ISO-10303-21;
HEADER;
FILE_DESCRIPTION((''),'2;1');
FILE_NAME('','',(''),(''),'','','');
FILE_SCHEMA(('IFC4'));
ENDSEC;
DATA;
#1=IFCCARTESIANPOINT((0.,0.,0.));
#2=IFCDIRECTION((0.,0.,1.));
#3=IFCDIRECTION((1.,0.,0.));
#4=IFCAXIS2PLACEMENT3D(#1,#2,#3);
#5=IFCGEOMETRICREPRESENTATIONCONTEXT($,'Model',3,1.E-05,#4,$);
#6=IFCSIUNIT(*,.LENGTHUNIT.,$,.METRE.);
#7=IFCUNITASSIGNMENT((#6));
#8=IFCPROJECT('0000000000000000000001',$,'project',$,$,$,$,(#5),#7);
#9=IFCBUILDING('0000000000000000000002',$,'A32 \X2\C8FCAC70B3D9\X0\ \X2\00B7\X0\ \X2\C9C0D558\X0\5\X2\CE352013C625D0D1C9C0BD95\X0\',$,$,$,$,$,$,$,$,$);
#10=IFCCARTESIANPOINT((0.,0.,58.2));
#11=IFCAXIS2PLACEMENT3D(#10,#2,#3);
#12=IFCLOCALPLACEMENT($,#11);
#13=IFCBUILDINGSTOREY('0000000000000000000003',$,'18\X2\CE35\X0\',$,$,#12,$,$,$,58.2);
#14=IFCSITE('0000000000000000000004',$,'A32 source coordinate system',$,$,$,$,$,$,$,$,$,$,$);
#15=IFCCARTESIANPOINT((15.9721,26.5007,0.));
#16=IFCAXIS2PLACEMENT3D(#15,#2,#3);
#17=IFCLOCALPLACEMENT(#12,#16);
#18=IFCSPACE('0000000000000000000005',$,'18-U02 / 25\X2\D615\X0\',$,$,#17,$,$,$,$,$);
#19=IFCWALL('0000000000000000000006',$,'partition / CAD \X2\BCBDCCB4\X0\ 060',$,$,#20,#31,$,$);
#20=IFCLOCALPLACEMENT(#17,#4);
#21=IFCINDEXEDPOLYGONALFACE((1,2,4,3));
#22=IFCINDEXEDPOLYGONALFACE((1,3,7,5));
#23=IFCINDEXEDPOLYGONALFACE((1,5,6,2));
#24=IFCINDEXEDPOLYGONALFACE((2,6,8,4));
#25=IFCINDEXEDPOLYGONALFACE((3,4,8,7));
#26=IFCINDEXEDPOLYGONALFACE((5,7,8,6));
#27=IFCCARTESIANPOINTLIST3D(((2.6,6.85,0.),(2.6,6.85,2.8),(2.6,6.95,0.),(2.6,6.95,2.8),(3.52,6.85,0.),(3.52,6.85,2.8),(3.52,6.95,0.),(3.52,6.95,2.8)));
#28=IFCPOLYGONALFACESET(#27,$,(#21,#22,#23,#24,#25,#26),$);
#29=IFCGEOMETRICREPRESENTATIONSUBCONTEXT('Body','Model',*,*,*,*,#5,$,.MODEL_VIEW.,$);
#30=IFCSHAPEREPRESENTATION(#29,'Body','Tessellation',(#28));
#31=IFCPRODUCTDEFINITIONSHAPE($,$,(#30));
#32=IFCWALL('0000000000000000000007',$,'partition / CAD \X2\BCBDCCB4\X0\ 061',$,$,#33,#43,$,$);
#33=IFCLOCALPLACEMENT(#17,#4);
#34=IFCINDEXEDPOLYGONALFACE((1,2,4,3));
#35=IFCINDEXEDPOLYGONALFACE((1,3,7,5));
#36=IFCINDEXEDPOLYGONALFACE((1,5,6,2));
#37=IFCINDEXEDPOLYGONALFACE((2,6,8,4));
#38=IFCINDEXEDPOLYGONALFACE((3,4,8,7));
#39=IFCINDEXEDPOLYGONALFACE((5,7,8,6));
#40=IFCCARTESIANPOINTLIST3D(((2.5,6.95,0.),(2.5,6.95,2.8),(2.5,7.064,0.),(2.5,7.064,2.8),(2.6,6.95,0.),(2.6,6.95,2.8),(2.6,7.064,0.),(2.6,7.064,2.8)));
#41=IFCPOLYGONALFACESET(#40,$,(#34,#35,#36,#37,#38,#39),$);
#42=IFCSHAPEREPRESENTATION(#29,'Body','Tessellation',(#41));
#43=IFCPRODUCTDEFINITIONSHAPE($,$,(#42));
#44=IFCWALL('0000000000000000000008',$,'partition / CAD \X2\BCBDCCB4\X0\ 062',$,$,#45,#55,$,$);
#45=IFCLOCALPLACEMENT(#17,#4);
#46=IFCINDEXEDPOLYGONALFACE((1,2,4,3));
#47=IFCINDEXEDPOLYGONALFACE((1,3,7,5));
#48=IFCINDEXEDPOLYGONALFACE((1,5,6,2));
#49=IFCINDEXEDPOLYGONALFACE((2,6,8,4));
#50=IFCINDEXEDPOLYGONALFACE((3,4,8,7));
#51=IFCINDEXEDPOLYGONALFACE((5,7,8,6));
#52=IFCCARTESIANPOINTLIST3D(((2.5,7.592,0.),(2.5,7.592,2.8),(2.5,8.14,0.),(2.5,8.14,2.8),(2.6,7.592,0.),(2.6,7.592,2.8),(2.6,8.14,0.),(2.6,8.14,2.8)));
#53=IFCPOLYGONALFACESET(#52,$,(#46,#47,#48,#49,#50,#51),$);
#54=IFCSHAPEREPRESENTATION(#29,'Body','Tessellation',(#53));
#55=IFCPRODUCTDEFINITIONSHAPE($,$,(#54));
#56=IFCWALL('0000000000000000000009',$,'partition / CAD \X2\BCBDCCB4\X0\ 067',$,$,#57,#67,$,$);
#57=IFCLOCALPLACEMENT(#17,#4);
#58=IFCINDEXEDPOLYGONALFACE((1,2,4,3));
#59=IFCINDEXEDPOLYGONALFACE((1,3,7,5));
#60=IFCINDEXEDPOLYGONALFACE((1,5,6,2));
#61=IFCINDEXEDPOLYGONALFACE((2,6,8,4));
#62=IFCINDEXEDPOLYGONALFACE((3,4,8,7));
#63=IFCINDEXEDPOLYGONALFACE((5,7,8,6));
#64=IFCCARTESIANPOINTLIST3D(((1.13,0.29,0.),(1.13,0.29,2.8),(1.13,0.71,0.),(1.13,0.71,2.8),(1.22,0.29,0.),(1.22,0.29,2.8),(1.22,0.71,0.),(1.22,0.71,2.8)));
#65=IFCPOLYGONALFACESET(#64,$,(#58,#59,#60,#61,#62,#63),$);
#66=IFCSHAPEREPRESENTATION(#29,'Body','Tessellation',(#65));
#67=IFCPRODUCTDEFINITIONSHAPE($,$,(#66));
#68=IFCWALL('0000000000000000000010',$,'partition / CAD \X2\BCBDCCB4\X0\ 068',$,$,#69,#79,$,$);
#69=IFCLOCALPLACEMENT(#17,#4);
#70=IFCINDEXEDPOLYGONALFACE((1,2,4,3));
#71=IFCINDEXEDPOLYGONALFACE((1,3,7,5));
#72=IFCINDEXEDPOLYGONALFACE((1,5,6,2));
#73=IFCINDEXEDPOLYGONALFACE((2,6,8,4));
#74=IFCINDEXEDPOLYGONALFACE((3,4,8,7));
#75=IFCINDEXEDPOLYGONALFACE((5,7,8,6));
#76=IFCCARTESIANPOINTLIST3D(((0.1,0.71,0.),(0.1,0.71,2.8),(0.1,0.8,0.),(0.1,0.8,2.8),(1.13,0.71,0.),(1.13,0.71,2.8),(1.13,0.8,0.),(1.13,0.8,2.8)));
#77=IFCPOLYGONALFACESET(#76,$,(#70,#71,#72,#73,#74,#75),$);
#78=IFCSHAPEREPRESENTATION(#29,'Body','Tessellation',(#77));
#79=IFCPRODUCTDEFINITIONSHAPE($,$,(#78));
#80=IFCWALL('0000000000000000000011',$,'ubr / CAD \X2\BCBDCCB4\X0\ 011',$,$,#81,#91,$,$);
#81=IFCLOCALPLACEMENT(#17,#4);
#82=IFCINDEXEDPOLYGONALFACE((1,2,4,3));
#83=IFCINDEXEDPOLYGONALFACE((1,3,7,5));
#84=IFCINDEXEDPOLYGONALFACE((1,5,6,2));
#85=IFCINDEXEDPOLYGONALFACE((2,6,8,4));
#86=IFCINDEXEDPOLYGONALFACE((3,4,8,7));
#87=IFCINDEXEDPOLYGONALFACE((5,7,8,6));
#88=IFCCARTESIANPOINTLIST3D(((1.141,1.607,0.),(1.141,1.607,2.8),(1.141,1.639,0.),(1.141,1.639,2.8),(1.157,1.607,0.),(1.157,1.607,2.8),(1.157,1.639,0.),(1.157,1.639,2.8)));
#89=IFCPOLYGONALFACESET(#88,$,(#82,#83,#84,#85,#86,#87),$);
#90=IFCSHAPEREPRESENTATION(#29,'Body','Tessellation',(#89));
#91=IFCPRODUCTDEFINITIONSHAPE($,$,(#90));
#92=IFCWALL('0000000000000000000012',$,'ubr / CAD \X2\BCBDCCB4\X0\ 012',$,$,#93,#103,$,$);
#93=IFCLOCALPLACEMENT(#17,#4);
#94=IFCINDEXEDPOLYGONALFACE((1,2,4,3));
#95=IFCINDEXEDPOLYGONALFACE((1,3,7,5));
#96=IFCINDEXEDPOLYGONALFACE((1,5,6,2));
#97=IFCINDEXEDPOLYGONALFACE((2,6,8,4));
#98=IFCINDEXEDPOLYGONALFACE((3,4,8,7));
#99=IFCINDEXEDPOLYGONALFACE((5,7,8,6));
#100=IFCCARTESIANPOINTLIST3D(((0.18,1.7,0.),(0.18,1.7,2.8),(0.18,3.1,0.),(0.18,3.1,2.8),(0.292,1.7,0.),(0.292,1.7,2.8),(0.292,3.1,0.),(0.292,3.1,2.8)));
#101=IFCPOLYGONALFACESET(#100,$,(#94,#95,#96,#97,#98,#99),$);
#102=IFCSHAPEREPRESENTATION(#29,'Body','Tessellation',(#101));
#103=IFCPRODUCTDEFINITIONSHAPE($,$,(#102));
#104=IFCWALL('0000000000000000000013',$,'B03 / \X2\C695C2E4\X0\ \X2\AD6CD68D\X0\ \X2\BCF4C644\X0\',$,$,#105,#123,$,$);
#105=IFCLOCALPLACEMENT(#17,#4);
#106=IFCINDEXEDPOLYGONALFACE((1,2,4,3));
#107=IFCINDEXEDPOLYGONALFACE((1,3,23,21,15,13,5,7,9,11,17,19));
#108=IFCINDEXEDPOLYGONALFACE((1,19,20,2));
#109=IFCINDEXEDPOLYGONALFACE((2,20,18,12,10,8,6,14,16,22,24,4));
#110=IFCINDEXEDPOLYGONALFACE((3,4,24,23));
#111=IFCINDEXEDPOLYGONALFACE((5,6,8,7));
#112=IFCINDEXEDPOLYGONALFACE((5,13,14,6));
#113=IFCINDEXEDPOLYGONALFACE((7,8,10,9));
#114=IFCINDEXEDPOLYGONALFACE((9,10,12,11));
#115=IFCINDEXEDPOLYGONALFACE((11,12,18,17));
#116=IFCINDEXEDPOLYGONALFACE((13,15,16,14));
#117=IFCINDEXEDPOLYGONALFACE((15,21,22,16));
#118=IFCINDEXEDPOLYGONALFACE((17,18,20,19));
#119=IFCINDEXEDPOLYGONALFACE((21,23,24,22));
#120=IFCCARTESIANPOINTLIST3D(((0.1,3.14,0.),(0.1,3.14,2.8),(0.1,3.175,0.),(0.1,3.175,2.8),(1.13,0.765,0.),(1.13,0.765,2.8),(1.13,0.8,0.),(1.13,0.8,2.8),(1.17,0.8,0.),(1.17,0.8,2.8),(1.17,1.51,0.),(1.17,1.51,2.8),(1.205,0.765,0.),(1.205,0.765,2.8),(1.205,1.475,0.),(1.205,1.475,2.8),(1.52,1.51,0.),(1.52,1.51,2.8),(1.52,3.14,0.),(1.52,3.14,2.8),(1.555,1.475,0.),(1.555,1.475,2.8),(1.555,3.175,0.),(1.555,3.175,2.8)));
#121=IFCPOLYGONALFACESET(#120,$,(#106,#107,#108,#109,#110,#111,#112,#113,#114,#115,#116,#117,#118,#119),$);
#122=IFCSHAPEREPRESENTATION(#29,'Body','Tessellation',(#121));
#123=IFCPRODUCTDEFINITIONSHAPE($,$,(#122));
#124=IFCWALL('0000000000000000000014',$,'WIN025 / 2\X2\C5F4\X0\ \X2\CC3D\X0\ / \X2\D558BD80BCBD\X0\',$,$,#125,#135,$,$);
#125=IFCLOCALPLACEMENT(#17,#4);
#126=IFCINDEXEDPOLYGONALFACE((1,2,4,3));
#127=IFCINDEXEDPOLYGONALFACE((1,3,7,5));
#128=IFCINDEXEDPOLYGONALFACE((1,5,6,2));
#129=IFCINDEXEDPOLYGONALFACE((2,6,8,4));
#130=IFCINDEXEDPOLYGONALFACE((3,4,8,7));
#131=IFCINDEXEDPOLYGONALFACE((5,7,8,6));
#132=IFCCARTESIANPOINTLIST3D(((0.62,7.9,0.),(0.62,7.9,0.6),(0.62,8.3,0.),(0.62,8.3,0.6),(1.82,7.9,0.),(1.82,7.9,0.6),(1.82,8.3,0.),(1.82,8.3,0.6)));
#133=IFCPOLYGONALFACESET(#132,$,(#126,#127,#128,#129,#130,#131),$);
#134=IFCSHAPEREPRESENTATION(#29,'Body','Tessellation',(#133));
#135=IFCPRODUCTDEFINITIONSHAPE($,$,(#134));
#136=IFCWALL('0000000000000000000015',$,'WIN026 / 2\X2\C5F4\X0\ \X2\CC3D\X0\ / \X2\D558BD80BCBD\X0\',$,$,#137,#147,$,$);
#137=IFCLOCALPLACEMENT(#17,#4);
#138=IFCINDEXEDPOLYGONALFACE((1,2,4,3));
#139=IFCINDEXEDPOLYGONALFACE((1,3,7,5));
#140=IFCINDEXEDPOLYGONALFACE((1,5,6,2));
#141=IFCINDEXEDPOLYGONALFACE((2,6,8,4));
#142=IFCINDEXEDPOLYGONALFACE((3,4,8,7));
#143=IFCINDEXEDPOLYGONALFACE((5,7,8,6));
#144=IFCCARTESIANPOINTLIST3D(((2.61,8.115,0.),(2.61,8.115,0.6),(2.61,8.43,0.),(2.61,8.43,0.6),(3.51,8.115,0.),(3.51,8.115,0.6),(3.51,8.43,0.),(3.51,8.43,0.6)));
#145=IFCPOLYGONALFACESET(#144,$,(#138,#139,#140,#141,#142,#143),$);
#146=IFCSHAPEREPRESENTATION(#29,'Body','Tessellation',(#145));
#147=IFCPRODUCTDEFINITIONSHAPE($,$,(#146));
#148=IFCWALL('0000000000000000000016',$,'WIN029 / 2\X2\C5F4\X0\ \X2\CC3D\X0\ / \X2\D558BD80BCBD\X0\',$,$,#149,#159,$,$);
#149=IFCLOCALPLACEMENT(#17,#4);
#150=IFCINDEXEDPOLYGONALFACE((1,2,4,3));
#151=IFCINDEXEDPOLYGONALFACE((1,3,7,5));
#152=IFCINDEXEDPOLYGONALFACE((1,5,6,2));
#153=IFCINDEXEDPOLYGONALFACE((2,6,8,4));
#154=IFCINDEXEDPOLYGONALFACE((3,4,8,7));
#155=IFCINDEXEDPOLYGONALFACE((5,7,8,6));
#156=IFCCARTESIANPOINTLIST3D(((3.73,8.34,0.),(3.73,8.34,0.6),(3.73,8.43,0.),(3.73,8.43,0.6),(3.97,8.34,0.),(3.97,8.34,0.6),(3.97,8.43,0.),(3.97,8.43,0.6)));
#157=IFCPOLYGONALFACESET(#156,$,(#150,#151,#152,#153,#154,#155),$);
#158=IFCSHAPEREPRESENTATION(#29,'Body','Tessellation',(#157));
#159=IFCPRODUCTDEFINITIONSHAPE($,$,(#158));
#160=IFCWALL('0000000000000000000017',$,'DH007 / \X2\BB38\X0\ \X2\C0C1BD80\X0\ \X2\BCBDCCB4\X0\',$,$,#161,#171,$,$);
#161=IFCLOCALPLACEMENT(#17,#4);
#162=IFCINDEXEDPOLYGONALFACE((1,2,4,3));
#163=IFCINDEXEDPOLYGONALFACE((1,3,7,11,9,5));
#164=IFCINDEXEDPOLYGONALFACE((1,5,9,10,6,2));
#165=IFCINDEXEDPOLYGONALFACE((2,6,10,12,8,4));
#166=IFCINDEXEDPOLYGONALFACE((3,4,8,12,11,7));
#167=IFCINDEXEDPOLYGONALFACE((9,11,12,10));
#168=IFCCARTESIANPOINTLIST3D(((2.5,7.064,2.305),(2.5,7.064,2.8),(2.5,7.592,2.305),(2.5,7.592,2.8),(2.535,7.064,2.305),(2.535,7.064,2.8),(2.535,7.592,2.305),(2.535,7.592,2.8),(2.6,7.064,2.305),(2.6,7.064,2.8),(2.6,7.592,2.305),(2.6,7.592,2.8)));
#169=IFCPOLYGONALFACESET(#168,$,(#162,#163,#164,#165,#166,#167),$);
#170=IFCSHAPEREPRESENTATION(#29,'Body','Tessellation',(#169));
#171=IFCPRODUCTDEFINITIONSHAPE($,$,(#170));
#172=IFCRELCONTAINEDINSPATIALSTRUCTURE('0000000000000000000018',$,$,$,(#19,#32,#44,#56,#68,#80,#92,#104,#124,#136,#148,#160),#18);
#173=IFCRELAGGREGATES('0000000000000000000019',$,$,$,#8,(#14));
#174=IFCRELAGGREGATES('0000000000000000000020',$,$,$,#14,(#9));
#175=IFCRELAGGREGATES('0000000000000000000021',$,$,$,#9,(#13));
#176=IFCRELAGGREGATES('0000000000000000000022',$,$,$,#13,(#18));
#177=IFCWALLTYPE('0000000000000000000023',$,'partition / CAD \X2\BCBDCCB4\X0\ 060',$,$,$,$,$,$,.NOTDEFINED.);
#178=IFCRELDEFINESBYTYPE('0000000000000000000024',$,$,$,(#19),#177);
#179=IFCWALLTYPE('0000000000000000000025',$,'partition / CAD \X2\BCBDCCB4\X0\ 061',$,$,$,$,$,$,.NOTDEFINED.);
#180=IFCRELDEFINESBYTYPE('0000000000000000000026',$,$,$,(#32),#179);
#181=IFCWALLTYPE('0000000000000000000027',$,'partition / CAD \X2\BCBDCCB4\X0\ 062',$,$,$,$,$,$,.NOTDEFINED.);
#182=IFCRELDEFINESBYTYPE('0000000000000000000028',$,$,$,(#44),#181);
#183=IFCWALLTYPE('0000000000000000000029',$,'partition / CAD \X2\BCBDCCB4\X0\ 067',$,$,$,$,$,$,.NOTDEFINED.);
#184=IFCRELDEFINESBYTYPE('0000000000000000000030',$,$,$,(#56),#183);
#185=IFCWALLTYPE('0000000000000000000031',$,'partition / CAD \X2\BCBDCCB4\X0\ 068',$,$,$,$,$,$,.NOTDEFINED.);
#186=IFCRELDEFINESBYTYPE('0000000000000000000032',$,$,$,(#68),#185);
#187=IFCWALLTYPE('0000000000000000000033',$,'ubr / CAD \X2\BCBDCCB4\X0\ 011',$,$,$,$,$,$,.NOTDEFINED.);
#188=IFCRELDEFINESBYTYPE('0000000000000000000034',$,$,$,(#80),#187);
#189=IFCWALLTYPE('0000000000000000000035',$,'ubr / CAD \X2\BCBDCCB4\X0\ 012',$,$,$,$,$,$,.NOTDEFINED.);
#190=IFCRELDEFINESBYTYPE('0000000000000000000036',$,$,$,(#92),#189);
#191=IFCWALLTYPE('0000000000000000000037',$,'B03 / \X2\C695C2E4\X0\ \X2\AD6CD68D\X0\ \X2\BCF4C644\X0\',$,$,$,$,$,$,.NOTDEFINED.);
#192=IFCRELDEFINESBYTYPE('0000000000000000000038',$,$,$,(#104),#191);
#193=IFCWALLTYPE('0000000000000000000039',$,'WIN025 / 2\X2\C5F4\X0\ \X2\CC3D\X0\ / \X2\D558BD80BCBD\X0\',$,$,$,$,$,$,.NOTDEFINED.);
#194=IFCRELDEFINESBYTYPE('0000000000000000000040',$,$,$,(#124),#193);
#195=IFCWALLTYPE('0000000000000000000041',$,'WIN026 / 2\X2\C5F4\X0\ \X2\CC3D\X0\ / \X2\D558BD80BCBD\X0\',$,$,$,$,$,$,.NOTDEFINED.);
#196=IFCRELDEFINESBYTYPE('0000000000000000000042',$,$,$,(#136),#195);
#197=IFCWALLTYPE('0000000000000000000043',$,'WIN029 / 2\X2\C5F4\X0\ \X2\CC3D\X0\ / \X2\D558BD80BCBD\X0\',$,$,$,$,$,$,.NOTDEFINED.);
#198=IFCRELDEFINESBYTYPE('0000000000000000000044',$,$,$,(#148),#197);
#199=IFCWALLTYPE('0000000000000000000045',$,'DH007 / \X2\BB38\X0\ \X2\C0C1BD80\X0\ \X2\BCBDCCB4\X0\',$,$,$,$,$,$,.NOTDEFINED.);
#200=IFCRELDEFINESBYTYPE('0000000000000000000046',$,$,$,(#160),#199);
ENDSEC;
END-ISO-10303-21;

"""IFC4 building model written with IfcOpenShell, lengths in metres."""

from ifc_helpers import new_model, si_unit, frame, origin, origin_with_axes, place, context, subcontext, project, spatial, polyline, outline, extrude, source, transform, mapped, type_object, type_shapes, element, save


model = new_model("IFC4")

# Units and contexts
model_context = context("Model", 3, precision=1e-05, world=origin_with_axes())
body_context = subcontext(model_context, "Body", "Model", "MODEL_VIEW")
ifc_project = project(units=[si_unit("LENGTHUNIT", "METRE")], contexts=[model_context])

# Site, building, storey, space
site = spatial("IfcSite", under=ifc_project, Name="A32 source coordinate system")
building = spatial("IfcBuilding", under=site, Name="A32 주거동 · 지하5층–옥탑지붕")
storey_placement = place(None, frame((0.0, 0.0, 58.2), z_axis=(0.0, 0.0, 1.0), x_axis=(1.0, 0.0, 0.0)))
storey = spatial("IfcBuildingStorey", under=building, at=storey_placement, Name="18층", Elevation=58.2)
space_1_placement = place(storey_placement, frame((15.9721, 26.5007, 0.0), z_axis=(0.0, 0.0, 1.0), x_axis=(1.0, 0.0, 0.0)))
space_1 = spatial("IfcSpace", under=storey, at=space_1_placement, Name="18-U02 / 25형")

# Walls
wall_type_1 = type_object("IfcWallType", Name="partition / CAD 벽체 060", PredefinedType="NOTDEFINED")
shared_shape_1 = source(origin(), body_context, "Body", "SweptSolid", [
    extrude(outline(polyline([(3.52, 6.85), (2.6, 6.85), (2.6, 6.95), (3.52, 6.95), (3.52, 6.85)])), origin(), (0.0, 0.0, 1.0), 2.8),
])
type_shapes(wall_type_1, [shared_shape_1])
wall_1_placement = place(space_1_placement, origin_with_axes())
element("IfcWall", 1, at=wall_1_placement, inside=space_1, type_object=wall_type_1, Name="partition / CAD 벽체 060", context=body_context, shape_type="MappedRepresentation", body=[
    mapped(shared_shape_1, transform((0.0, 0.0, 0.0), scale=1.0)),
])
wall_type_2 = type_object("IfcWallType", Name="partition / CAD 벽체 061", PredefinedType="NOTDEFINED")
shared_shape_2 = source(origin(), body_context, "Body", "SweptSolid", [
    extrude(outline(polyline([(2.6, 7.064), (2.6, 6.95), (2.5, 6.95), (2.5, 7.064), (2.6, 7.064)])), origin(), (0.0, 0.0, 1.0), 2.8),
])
type_shapes(wall_type_2, [shared_shape_2])
wall_2_placement = place(space_1_placement, origin_with_axes())
element("IfcWall", 2, at=wall_2_placement, inside=space_1, type_object=wall_type_2, Name="partition / CAD 벽체 061", context=body_context, shape_type="MappedRepresentation", body=[
    mapped(shared_shape_2, transform((0.0, 0.0, 0.0), scale=1.0)),
])
wall_type_3 = type_object("IfcWallType", Name="partition / CAD 벽체 062", PredefinedType="NOTDEFINED")
shared_shape_3 = source(origin(), body_context, "Body", "SweptSolid", [
    extrude(outline(polyline([(2.5, 7.592), (2.5, 8.14), (2.6, 8.14), (2.6, 7.592), (2.5, 7.592)])), origin(), (0.0, 0.0, 1.0), 2.8),
])
type_shapes(wall_type_3, [shared_shape_3])
wall_3_placement = place(space_1_placement, origin_with_axes())
element("IfcWall", 3, at=wall_3_placement, inside=space_1, type_object=wall_type_3, Name="partition / CAD 벽체 062", context=body_context, shape_type="MappedRepresentation", body=[
    mapped(shared_shape_3, transform((0.0, 0.0, 0.0), scale=1.0)),
])
wall_type_4 = type_object("IfcWallType", Name="partition / CAD 벽체 067", PredefinedType="NOTDEFINED")
shared_shape_4 = source(origin(), body_context, "Body", "SweptSolid", [
    extrude(outline(polyline([(1.22, 0.71), (1.22, 0.29), (1.13, 0.29), (1.13, 0.71), (1.22, 0.71)])), origin(), (0.0, 0.0, 1.0), 2.8),
])
type_shapes(wall_type_4, [shared_shape_4])
wall_4_placement = place(space_1_placement, origin_with_axes())
element("IfcWall", 4, at=wall_4_placement, inside=space_1, type_object=wall_type_4, Name="partition / CAD 벽체 067", context=body_context, shape_type="MappedRepresentation", body=[
    mapped(shared_shape_4, transform((0.0, 0.0, 0.0), scale=1.0)),
])
wall_type_5 = type_object("IfcWallType", Name="partition / CAD 벽체 068", PredefinedType="NOTDEFINED")
shared_shape_5 = source(origin(), body_context, "Body", "SweptSolid", [
    extrude(outline(polyline([(1.13, 0.8), (1.13, 0.71), (0.1, 0.71), (0.1, 0.8), (1.13, 0.8)])), origin(), (0.0, 0.0, 1.0), 2.8),
])
type_shapes(wall_type_5, [shared_shape_5])
wall_5_placement = place(space_1_placement, origin_with_axes())
element("IfcWall", 5, at=wall_5_placement, inside=space_1, type_object=wall_type_5, Name="partition / CAD 벽체 068", context=body_context, shape_type="MappedRepresentation", body=[
    mapped(shared_shape_5, transform((0.0, 0.0, 0.0), scale=1.0)),
])
wall_type_6 = type_object("IfcWallType", Name="ubr / CAD 벽체 011", PredefinedType="NOTDEFINED")
shared_shape_6 = source(origin(), body_context, "Body", "SweptSolid", [
    extrude(outline(polyline([(1.141, 1.607), (1.141, 1.639), (1.157, 1.639), (1.157, 1.607), (1.141, 1.607)])), origin(), (0.0, 0.0, 1.0), 2.8),
])
type_shapes(wall_type_6, [shared_shape_6])
wall_6_placement = place(space_1_placement, origin_with_axes())
element("IfcWall", 6, at=wall_6_placement, inside=space_1, type_object=wall_type_6, Name="ubr / CAD 벽체 011", context=body_context, shape_type="MappedRepresentation", body=[
    mapped(shared_shape_6, transform((0.0, 0.0, 0.0), scale=1.0)),
])
wall_type_7 = type_object("IfcWallType", Name="ubr / CAD 벽체 012", PredefinedType="NOTDEFINED")
shared_shape_7 = source(origin(), body_context, "Body", "SweptSolid", [
    extrude(outline(polyline([(0.18, 1.7), (0.18, 3.1), (0.292, 3.1), (0.292, 1.7), (0.18, 1.7)])), origin(), (0.0, 0.0, 1.0), 2.8),
])
type_shapes(wall_type_7, [shared_shape_7])
wall_7_placement = place(space_1_placement, origin_with_axes())
element("IfcWall", 7, at=wall_7_placement, inside=space_1, type_object=wall_type_7, Name="ubr / CAD 벽체 012", context=body_context, shape_type="MappedRepresentation", body=[
    mapped(shared_shape_7, transform((0.0, 0.0, 0.0), scale=1.0)),
])
wall_type_8 = type_object("IfcWallType", Name="B03 / 욕실 구획 보완", PredefinedType="NOTDEFINED")
shared_shape_8 = source(origin(), body_context, "Body", "SweptSolid", [
    extrude(outline(polyline([(1.13, 0.765), (1.13, 0.8), (1.17, 0.8), (1.17, 1.51), (1.52, 1.51), (1.52, 3.14), (0.1, 3.14), (0.1, 3.175), (1.555, 3.175), (1.555, 1.475), (1.205, 1.475), (1.205, 0.765), (1.13, 0.765)])), origin(), (0.0, 0.0, 1.0), 2.8),
])
type_shapes(wall_type_8, [shared_shape_8])
wall_8_placement = place(space_1_placement, origin_with_axes())
element("IfcWall", 8, at=wall_8_placement, inside=space_1, type_object=wall_type_8, Name="B03 / 욕실 구획 보완", context=body_context, shape_type="MappedRepresentation", body=[
    mapped(shared_shape_8, transform((0.0, 0.0, 0.0), scale=1.0)),
])
wall_type_9 = type_object("IfcWallType", Name="WIN025 / 2열 창 / 하부벽", PredefinedType="NOTDEFINED")
shared_shape_9 = source(origin(), body_context, "Body", "SweptSolid", [
    extrude(outline(polyline([(1.82, 8.3), (1.82, 7.9), (0.62, 7.9), (0.62, 8.3), (1.82, 8.3)])), origin(), (0.0, 0.0, 1.0), 0.6),
])
type_shapes(wall_type_9, [shared_shape_9])
wall_9_placement = place(space_1_placement, origin_with_axes())
element("IfcWall", 9, at=wall_9_placement, inside=space_1, type_object=wall_type_9, Name="WIN025 / 2열 창 / 하부벽", context=body_context, shape_type="MappedRepresentation", body=[
    mapped(shared_shape_9, transform((0.0, 0.0, 0.0), scale=1.0)),
])
wall_type_10 = type_object("IfcWallType", Name="WIN026 / 2열 창 / 하부벽", PredefinedType="NOTDEFINED")
shared_shape_10 = source(origin(), body_context, "Body", "SweptSolid", [
    extrude(outline(polyline([(3.51, 8.43), (3.51, 8.115), (2.61, 8.115), (2.61, 8.43), (3.51, 8.43)])), origin(), (0.0, 0.0, 1.0), 0.6),
])
type_shapes(wall_type_10, [shared_shape_10])
wall_10_placement = place(space_1_placement, origin_with_axes())
element("IfcWall", 10, at=wall_10_placement, inside=space_1, type_object=wall_type_10, Name="WIN026 / 2열 창 / 하부벽", context=body_context, shape_type="MappedRepresentation", body=[
    mapped(shared_shape_10, transform((0.0, 0.0, 0.0), scale=1.0)),
])
wall_type_11 = type_object("IfcWallType", Name="WIN029 / 2열 창 / 하부벽", PredefinedType="NOTDEFINED")
shared_shape_11 = source(origin(), body_context, "Body", "SweptSolid", [
    extrude(outline(polyline([(3.97, 8.43), (3.97, 8.34), (3.73, 8.34), (3.73, 8.43), (3.97, 8.43)])), origin(), (0.0, 0.0, 1.0), 0.6),
])
type_shapes(wall_type_11, [shared_shape_11])
wall_11_placement = place(space_1_placement, origin_with_axes())
element("IfcWall", 11, at=wall_11_placement, inside=space_1, type_object=wall_type_11, Name="WIN029 / 2열 창 / 하부벽", context=body_context, shape_type="MappedRepresentation", body=[
    mapped(shared_shape_11, transform((0.0, 0.0, 0.0), scale=1.0)),
])
wall_type_12 = type_object("IfcWallType", Name="DH007 / 문 상부 벽체", PredefinedType="NOTDEFINED")
shared_shape_12 = source(origin(), body_context, "Body", "SweptSolid", [
    extrude(outline(polyline([(2.5, 7.592), (2.535, 7.592), (2.6, 7.592), (2.6, 7.064), (2.535, 7.064), (2.5, 7.064), (2.5, 7.592)])), frame((0.0, 0.0, 2.305)), (0.0, 0.0, 1.0), 0.495),
])
type_shapes(wall_type_12, [shared_shape_12])
wall_12_placement = place(space_1_placement, origin_with_axes())
element("IfcWall", 12, at=wall_12_placement, inside=space_1, type_object=wall_type_12, Name="DH007 / 문 상부 벽체", context=body_context, shape_type="MappedRepresentation", body=[
    mapped(shared_shape_12, transform((0.0, 0.0, 0.0), scale=1.0)),
])

save(model, "model.ifc")
